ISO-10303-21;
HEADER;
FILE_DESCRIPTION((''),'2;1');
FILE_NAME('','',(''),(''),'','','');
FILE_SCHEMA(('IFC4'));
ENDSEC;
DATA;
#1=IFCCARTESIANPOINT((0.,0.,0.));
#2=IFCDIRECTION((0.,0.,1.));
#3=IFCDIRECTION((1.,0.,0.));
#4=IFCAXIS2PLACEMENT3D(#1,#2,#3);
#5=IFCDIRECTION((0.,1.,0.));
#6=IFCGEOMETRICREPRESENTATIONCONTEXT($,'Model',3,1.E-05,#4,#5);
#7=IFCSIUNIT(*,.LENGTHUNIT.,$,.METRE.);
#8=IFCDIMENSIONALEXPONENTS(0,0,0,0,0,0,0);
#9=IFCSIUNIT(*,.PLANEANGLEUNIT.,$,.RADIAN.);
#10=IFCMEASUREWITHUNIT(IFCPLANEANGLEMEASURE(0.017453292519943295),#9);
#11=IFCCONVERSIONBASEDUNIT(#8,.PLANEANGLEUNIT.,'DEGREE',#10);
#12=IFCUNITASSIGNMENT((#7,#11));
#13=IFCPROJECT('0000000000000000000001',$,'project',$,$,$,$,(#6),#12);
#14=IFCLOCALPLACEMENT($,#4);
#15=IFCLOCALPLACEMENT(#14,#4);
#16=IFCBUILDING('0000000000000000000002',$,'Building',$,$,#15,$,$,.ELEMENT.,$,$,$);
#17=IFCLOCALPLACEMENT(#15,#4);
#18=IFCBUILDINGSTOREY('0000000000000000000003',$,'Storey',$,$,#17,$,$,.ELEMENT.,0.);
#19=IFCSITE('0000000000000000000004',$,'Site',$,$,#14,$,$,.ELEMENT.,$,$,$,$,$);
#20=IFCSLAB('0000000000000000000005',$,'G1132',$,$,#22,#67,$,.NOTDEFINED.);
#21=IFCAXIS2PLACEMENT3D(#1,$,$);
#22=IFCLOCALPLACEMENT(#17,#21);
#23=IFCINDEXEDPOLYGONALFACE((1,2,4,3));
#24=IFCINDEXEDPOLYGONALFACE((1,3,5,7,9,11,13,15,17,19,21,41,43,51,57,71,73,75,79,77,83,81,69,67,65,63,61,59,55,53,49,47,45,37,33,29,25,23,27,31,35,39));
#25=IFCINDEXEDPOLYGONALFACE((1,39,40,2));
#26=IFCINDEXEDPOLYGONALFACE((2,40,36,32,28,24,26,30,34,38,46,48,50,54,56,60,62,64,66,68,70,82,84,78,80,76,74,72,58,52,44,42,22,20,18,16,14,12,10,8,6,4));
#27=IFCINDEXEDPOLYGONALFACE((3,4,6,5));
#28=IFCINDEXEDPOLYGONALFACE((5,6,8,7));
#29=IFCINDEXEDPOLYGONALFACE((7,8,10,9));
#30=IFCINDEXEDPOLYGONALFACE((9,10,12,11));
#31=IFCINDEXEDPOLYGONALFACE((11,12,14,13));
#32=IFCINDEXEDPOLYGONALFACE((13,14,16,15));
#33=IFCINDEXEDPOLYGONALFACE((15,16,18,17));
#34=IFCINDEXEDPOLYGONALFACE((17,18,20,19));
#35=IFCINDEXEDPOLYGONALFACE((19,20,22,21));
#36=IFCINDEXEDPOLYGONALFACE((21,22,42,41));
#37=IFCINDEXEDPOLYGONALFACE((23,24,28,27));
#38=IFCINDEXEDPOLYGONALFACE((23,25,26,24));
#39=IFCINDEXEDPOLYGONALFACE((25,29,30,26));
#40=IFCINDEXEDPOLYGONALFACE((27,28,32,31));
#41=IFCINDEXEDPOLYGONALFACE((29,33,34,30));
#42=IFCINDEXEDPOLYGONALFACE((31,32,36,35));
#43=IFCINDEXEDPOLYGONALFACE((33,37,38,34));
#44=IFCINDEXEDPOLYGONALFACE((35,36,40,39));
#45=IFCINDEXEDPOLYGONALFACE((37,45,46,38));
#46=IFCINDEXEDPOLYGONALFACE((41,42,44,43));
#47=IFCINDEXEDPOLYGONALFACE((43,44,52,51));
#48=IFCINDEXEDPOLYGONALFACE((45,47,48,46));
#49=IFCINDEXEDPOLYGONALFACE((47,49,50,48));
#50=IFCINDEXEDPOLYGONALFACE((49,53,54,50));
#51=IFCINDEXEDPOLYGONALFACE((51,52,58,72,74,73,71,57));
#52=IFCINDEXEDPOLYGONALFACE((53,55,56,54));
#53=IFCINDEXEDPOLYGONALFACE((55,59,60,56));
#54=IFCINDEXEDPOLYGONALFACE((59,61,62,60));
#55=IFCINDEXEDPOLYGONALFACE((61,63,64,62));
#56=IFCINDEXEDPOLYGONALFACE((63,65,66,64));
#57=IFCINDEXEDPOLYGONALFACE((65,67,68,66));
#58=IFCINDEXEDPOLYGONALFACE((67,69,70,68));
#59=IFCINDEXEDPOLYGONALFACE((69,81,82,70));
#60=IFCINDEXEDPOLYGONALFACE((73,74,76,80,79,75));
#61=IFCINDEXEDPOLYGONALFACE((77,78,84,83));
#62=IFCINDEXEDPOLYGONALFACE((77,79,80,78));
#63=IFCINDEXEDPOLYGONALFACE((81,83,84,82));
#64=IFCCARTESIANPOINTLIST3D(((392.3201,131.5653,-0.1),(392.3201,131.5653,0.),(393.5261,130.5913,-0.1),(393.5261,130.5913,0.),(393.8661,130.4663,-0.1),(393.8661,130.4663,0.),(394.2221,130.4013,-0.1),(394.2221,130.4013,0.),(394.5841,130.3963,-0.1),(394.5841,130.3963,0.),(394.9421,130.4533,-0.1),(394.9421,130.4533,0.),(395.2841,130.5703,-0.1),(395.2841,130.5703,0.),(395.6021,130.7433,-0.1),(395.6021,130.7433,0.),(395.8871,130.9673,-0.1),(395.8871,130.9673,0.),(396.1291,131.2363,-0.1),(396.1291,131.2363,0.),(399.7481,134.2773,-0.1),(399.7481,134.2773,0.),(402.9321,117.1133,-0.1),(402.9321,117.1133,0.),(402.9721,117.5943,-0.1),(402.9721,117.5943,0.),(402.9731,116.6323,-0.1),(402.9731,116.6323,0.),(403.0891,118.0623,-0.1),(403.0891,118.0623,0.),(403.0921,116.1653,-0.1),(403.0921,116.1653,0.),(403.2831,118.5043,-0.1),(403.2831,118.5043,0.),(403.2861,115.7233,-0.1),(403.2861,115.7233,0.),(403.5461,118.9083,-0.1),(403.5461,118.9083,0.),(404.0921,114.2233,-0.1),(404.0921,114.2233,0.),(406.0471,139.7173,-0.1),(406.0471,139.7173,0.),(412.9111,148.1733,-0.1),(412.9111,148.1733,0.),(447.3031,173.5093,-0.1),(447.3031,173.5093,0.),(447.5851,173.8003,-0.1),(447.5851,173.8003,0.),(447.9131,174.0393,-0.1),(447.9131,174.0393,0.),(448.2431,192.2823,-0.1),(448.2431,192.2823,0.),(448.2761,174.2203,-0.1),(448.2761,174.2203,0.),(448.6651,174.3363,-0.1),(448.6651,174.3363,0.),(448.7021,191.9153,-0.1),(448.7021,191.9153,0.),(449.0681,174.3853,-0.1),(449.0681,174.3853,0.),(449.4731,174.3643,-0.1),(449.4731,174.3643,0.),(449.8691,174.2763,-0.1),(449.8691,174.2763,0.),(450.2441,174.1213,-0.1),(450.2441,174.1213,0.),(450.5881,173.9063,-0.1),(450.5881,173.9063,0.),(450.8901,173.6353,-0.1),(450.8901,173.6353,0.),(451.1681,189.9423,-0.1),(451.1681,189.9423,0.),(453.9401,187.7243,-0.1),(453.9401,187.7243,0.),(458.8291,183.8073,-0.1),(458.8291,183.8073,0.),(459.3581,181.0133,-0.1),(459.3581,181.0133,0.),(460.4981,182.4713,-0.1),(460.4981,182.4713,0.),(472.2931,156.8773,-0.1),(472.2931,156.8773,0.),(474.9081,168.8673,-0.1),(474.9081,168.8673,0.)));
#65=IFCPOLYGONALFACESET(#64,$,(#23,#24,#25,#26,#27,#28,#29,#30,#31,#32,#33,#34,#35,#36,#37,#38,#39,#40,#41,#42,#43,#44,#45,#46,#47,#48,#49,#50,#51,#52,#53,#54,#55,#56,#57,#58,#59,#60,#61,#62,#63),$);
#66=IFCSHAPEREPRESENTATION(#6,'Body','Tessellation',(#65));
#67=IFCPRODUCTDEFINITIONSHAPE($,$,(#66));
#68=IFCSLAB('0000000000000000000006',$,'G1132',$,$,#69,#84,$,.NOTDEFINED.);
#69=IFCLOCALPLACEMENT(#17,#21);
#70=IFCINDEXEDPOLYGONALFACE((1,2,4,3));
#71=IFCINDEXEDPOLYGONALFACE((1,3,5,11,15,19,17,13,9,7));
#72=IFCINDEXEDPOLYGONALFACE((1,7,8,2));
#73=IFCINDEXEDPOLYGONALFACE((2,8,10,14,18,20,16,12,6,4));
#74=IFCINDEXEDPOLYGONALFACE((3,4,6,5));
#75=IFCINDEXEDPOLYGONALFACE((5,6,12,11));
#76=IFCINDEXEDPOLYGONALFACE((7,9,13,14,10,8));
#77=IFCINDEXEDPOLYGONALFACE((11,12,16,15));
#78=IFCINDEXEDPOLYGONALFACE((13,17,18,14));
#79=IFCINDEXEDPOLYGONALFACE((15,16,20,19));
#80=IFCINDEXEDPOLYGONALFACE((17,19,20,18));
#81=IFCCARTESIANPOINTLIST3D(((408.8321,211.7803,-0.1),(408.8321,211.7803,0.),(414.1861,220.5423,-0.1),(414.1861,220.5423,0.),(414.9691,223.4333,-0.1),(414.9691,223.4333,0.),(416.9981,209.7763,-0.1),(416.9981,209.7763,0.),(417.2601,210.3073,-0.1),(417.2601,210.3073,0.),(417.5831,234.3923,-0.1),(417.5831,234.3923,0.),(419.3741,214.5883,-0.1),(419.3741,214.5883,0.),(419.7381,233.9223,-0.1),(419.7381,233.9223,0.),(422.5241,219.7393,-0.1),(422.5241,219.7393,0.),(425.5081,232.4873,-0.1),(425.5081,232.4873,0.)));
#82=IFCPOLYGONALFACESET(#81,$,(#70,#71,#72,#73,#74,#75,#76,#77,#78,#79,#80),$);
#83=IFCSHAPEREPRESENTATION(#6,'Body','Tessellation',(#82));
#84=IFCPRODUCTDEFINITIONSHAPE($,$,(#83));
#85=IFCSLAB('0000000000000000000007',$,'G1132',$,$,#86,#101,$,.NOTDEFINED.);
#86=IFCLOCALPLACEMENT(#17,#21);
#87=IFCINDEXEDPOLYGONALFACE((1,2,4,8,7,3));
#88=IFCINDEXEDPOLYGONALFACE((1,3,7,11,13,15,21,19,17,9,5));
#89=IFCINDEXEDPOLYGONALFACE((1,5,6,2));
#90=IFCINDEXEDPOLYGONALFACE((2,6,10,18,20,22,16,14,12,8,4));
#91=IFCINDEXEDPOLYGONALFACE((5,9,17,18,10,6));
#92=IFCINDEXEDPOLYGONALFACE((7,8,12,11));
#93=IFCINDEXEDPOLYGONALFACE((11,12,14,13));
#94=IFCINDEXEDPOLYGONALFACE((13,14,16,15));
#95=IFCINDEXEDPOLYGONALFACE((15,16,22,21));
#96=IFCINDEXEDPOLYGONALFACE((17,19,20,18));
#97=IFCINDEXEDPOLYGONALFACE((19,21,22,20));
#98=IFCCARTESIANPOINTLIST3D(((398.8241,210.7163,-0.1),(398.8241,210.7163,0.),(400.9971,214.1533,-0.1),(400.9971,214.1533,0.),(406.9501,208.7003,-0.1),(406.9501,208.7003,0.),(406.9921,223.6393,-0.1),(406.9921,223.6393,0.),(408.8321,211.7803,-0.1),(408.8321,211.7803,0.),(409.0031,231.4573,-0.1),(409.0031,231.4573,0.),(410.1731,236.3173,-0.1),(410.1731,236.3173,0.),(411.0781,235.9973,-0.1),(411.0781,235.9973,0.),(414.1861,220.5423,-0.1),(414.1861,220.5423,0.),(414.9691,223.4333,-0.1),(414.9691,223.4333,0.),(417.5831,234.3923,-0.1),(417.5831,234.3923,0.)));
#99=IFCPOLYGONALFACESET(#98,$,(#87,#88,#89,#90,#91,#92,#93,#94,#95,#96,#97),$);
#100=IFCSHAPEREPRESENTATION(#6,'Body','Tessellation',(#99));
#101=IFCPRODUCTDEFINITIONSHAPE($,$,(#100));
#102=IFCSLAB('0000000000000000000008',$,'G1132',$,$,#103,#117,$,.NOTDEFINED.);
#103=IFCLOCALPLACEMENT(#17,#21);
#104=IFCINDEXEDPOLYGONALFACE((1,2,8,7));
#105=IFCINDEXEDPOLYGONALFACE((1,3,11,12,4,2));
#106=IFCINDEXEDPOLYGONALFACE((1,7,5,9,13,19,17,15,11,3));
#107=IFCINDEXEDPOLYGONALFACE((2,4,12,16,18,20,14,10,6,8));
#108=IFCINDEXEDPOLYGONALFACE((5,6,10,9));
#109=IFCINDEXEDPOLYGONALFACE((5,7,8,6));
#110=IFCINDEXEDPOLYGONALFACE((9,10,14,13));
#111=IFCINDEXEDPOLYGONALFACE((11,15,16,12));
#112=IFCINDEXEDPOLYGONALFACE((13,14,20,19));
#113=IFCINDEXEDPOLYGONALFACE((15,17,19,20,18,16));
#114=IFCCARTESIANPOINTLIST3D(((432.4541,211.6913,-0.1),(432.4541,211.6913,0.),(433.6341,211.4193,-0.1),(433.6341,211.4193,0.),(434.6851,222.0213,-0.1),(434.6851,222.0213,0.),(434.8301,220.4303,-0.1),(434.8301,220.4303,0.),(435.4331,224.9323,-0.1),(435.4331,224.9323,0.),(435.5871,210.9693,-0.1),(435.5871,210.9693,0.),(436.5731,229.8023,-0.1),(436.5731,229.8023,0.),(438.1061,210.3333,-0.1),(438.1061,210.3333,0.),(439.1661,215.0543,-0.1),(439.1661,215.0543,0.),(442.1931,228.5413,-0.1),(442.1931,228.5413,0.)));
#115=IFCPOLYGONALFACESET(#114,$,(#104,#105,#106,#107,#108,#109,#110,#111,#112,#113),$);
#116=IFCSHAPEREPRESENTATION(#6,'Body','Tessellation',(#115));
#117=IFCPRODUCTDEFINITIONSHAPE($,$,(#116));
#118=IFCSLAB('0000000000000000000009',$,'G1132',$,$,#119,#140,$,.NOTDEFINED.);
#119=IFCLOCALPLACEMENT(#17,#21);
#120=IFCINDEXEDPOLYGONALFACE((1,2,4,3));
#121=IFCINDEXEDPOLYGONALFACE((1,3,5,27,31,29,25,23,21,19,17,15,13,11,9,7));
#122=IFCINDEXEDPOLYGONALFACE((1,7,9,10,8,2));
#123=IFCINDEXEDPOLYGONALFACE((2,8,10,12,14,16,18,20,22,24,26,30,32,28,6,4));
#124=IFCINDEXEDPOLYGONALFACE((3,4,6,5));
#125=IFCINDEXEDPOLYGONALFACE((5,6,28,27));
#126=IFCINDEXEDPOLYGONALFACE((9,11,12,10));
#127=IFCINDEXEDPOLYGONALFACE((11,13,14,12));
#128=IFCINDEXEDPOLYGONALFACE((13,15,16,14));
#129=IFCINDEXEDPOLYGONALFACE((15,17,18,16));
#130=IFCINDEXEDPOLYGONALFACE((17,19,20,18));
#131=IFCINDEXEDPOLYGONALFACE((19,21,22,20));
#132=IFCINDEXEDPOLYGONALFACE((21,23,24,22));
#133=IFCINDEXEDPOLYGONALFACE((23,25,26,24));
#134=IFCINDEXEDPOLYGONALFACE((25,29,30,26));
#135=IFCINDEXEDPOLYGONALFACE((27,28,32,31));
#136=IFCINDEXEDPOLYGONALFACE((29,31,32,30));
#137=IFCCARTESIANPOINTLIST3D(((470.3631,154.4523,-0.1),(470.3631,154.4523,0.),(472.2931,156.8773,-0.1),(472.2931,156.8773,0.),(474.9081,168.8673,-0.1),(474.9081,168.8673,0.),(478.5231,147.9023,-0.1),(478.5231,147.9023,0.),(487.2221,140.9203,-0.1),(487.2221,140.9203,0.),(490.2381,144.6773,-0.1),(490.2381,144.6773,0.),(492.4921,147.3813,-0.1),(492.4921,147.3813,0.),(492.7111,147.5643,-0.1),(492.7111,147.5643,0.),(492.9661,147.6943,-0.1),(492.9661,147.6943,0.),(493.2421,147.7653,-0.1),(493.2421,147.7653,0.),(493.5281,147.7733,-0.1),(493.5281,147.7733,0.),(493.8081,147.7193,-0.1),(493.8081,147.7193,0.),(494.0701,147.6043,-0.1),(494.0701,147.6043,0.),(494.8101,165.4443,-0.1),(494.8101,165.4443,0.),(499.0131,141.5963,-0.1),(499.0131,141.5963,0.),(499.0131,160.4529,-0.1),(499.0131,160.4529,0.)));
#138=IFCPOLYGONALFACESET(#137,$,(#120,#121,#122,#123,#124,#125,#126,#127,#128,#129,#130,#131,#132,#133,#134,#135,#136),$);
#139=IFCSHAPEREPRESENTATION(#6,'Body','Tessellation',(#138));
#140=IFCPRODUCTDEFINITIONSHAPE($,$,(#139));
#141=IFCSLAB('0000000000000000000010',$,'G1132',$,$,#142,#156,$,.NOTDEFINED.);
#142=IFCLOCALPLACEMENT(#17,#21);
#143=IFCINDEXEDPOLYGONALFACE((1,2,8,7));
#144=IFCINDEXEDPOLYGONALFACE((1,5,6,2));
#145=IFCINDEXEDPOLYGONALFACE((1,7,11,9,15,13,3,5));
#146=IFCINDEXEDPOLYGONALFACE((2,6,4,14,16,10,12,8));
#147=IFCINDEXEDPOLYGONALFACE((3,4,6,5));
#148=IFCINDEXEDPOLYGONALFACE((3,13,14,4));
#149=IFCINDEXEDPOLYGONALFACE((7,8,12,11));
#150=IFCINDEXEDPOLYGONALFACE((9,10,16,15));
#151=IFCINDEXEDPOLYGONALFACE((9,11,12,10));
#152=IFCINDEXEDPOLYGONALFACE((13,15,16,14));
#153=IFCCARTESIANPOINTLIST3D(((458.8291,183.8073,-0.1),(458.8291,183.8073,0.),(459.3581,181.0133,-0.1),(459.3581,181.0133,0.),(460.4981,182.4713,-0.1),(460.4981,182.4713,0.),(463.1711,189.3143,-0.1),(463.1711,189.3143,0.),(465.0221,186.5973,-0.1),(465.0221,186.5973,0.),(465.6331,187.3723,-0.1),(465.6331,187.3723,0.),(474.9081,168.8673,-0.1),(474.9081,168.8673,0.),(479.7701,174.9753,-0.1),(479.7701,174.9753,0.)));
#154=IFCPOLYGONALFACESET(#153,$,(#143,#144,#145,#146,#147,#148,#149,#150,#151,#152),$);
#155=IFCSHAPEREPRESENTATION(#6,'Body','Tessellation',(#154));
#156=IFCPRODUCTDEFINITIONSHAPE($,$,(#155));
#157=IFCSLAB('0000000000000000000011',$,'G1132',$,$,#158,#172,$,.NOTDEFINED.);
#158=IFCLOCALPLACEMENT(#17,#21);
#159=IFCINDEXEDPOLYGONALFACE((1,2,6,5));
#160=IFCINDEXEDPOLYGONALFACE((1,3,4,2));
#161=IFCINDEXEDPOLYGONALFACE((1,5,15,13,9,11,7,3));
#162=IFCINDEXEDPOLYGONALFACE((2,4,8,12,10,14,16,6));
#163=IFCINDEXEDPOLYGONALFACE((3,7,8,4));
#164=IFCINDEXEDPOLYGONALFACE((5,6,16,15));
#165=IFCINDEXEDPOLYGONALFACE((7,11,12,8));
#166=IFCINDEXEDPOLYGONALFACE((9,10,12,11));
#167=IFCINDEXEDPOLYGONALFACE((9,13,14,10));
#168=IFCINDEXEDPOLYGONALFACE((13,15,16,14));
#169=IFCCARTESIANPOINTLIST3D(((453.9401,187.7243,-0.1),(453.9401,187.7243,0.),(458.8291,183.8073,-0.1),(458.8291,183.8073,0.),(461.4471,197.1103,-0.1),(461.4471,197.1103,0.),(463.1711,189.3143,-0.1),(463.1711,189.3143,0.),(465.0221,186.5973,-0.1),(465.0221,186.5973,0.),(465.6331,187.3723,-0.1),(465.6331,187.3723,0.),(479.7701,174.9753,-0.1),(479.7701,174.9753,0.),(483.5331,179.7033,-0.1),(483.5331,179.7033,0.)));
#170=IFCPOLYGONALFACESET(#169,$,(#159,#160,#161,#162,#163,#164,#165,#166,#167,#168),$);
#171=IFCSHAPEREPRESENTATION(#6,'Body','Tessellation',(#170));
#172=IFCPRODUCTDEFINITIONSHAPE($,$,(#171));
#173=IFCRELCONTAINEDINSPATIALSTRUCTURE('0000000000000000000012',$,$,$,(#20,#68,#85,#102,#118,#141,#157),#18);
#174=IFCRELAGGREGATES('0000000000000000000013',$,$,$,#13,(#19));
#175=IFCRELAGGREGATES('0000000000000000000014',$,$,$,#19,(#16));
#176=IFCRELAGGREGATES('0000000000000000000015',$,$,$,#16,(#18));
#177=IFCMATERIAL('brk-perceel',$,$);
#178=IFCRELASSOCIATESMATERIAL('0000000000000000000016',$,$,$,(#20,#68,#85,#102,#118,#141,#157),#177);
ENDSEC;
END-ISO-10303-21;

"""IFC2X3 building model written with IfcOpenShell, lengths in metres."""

from ifc_helpers import new_model, entity, si_unit, converted_unit, direction, frame, origin_with_axes, place, context, project, spatial, polyline, outline, extrude, material, element, save


model = new_model("IFC2X3")

# Units and contexts
model_context = context("Model", 3, precision=1e-05, world=origin_with_axes(), true_north=direction((0.0, 1.0, 0.0)))
ifc_project = project(units=[si_unit("LENGTHUNIT", "METRE"), converted_unit("PLANEANGLEUNIT", "DEGREE", entity("IfcPlaneAngleMeasure", 0.017453292519943295), si_unit("PLANEANGLEUNIT", "RADIAN"), dimensions=[0, 0, 0, 0, 0, 0, 0])], contexts=[model_context])

# Site, building, storey
site_placement = place(None, origin_with_axes())
site = spatial("IfcSite", under=ifc_project, at=site_placement, Name="Site", CompositionType="ELEMENT")
building_placement = place(site_placement, origin_with_axes())
building = spatial("IfcBuilding", under=site, at=building_placement, Name="Building", CompositionType="ELEMENT")
storey_placement = place(building_placement, origin_with_axes())
storey = spatial("IfcBuildingStorey", under=building, at=storey_placement, Name="Storey", CompositionType="ELEMENT", Elevation=0.0)

# Slabs
ifc_material = material(Name="brk-perceel")
slab_1_placement = place(storey_placement, frame((0.0, 0.0, -0.1), z_axis=(0.0, 0.0, 1.0), x_axis=(1.0, 0.0, 0.0)))
element("IfcSlab", 1, at=slab_1_placement, inside=storey, material=ifc_material, Name="G1132", PredefinedType="NOTDEFINED", context=model_context, shape_type="SweptSolid", body=[
    extrude(outline(polyline([(458.8291, 183.8073), (460.4981, 182.4713), (459.3581, 181.0133), (474.9081, 168.8673), (472.2931, 156.8773), (450.8901, 173.6353), (450.5881, 173.9063), (450.2441, 174.1213), (449.8691, 174.2763), (449.4731, 174.3643), (449.0681, 174.3853), (448.6651, 174.3363), (448.2761, 174.2203), (447.9131, 174.0393), (447.5851, 173.8003), (447.3031, 173.5093), (403.5461, 118.9083), (403.2831, 118.5043), (403.0891, 118.0623), (402.9721, 117.5943), (402.9321, 117.1133), (402.9731, 116.6323), (403.0921, 116.1653), (403.2861, 115.7233), (404.0921, 114.2233), (392.3201, 131.5653), (393.5261, 130.5913), (393.8661, 130.4663), (394.2221, 130.4013), (394.5841, 130.3963), (394.9421, 130.4533), (395.2841, 130.5703), (395.6021, 130.7433), (395.8871, 130.9673), (396.1291, 131.2363), (399.7481, 134.2773), (406.0471, 139.7173), (412.9111, 148.1733), (448.2431, 192.2823), (448.7021, 191.9153), (451.1681, 189.9423), (453.9401, 187.7243), (458.8291, 183.8073)])), origin_with_axes(), (0.0, 0.0, 1.0), 0.1),
])
slab_2_placement = place(storey_placement, frame((0.0, 0.0, -0.1), z_axis=(0.0, 0.0, 1.0), x_axis=(1.0, 0.0, 0.0)))
element("IfcSlab", 2, at=slab_2_placement, inside=storey, material=ifc_material, Name="G1132", PredefinedType="NOTDEFINED", context=model_context, shape_type="SweptSolid", body=[
    extrude(outline(polyline([(416.9981, 209.7763), (408.8321, 211.7803), (414.1861, 220.5423), (414.9691, 223.4333), (417.5831, 234.3923), (419.7381, 233.9223), (425.5081, 232.4873), (422.5241, 219.7393), (419.3741, 214.5883), (417.2601, 210.3073), (416.9981, 209.7763)])), origin_with_axes(), (0.0, 0.0, 1.0), 0.1),
])
slab_3_placement = place(storey_placement, frame((0.0, 0.0, -0.1), z_axis=(0.0, 0.0, 1.0), x_axis=(1.0, 0.0, 0.0)))
element("IfcSlab", 3, at=slab_3_placement, inside=storey, material=ifc_material, Name="G1132", PredefinedType="NOTDEFINED", context=model_context, shape_type="SweptSolid", body=[
    extrude(outline(polyline([(406.9501, 208.7003), (398.8241, 210.7163), (400.9971, 214.1533), (406.9921, 223.6393), (409.0031, 231.4573), (410.1731, 236.3173), (411.0781, 235.9973), (417.5831, 234.3923), (414.9691, 223.4333), (414.1861, 220.5423), (408.8321, 211.7803), (406.9501, 208.7003)])), origin_with_axes(), (0.0, 0.0, 1.0), 0.1),
])
slab_4_placement = place(storey_placement, frame((0.0, 0.0, -0.1), z_axis=(0.0, 0.0, 1.0), x_axis=(1.0, 0.0, 0.0)))
element("IfcSlab", 4, at=slab_4_placement, inside=storey, material=ifc_material, Name="G1132", PredefinedType="NOTDEFINED", context=model_context, shape_type="SweptSolid", body=[
    extrude(outline(polyline([(438.1061, 210.3333), (435.5871, 210.9693), (433.6341, 211.4193), (432.4541, 211.6913), (434.8301, 220.4303), (434.6851, 222.0213), (435.4331, 224.9323), (436.5731, 229.8023), (442.1931, 228.5413), (439.1661, 215.0543), (438.1061, 210.3333)])), origin_with_axes(), (0.0, 0.0, 1.0), 0.1),
])
slab_5_placement = place(storey_placement, frame((0.0, 0.0, -0.1), z_axis=(0.0, 0.0, 1.0), x_axis=(1.0, 0.0, 0.0)))
element("IfcSlab", 5, at=slab_5_placement, inside=storey, material=ifc_material, Name="G1132", PredefinedType="NOTDEFINED", context=model_context, shape_type="SweptSolid", body=[
    extrude(outline(polyline([(494.0701, 147.6043), (493.8081, 147.7193), (493.5281, 147.7733), (493.2421, 147.7653), (492.9661, 147.6943), (492.7111, 147.5643), (492.4921, 147.3813), (490.2381, 144.6773), (487.2221, 140.9203), (478.5231, 147.9023), (470.3631, 154.4523), (472.2931, 156.8773), (474.9081, 168.8673), (494.8101, 165.4443), (499.0131, 160.4529), (499.0131, 141.5963), (494.0701, 147.6043)])), origin_with_axes(), (0.0, 0.0, 1.0), 0.1),
])
slab_6_placement = place(storey_placement, frame((0.0, 0.0, -0.1), z_axis=(0.0, 0.0, 1.0), x_axis=(1.0, 0.0, 0.0)))
element("IfcSlab", 6, at=slab_6_placement, inside=storey, material=ifc_material, Name="G1132", PredefinedType="NOTDEFINED", context=model_context, shape_type="SweptSolid", body=[
    extrude(outline(polyline([(460.4981, 182.4713), (458.8291, 183.8073), (463.1711, 189.3143), (465.6331, 187.3723), (465.0221, 186.5973), (479.7701, 174.9753), (474.9081, 168.8673), (459.3581, 181.0133), (460.4981, 182.4713)])), origin_with_axes(), (0.0, 0.0, 1.0), 0.1),
])
slab_7_placement = place(storey_placement, frame((0.0, 0.0, -0.1), z_axis=(0.0, 0.0, 1.0), x_axis=(1.0, 0.0, 0.0)))
element("IfcSlab", 7, at=slab_7_placement, inside=storey, material=ifc_material, Name="G1132", PredefinedType="NOTDEFINED", context=model_context, shape_type="SweptSolid", body=[
    extrude(outline(polyline([(453.9401, 187.7243), (461.4471, 197.1103), (483.5331, 179.7033), (479.7701, 174.9753), (465.0221, 186.5973), (465.6331, 187.3723), (463.1711, 189.3143), (458.8291, 183.8073), (453.9401, 187.7243)])), origin_with_axes(), (0.0, 0.0, 1.0), 0.1),
])

save(model, "model.ifc")
